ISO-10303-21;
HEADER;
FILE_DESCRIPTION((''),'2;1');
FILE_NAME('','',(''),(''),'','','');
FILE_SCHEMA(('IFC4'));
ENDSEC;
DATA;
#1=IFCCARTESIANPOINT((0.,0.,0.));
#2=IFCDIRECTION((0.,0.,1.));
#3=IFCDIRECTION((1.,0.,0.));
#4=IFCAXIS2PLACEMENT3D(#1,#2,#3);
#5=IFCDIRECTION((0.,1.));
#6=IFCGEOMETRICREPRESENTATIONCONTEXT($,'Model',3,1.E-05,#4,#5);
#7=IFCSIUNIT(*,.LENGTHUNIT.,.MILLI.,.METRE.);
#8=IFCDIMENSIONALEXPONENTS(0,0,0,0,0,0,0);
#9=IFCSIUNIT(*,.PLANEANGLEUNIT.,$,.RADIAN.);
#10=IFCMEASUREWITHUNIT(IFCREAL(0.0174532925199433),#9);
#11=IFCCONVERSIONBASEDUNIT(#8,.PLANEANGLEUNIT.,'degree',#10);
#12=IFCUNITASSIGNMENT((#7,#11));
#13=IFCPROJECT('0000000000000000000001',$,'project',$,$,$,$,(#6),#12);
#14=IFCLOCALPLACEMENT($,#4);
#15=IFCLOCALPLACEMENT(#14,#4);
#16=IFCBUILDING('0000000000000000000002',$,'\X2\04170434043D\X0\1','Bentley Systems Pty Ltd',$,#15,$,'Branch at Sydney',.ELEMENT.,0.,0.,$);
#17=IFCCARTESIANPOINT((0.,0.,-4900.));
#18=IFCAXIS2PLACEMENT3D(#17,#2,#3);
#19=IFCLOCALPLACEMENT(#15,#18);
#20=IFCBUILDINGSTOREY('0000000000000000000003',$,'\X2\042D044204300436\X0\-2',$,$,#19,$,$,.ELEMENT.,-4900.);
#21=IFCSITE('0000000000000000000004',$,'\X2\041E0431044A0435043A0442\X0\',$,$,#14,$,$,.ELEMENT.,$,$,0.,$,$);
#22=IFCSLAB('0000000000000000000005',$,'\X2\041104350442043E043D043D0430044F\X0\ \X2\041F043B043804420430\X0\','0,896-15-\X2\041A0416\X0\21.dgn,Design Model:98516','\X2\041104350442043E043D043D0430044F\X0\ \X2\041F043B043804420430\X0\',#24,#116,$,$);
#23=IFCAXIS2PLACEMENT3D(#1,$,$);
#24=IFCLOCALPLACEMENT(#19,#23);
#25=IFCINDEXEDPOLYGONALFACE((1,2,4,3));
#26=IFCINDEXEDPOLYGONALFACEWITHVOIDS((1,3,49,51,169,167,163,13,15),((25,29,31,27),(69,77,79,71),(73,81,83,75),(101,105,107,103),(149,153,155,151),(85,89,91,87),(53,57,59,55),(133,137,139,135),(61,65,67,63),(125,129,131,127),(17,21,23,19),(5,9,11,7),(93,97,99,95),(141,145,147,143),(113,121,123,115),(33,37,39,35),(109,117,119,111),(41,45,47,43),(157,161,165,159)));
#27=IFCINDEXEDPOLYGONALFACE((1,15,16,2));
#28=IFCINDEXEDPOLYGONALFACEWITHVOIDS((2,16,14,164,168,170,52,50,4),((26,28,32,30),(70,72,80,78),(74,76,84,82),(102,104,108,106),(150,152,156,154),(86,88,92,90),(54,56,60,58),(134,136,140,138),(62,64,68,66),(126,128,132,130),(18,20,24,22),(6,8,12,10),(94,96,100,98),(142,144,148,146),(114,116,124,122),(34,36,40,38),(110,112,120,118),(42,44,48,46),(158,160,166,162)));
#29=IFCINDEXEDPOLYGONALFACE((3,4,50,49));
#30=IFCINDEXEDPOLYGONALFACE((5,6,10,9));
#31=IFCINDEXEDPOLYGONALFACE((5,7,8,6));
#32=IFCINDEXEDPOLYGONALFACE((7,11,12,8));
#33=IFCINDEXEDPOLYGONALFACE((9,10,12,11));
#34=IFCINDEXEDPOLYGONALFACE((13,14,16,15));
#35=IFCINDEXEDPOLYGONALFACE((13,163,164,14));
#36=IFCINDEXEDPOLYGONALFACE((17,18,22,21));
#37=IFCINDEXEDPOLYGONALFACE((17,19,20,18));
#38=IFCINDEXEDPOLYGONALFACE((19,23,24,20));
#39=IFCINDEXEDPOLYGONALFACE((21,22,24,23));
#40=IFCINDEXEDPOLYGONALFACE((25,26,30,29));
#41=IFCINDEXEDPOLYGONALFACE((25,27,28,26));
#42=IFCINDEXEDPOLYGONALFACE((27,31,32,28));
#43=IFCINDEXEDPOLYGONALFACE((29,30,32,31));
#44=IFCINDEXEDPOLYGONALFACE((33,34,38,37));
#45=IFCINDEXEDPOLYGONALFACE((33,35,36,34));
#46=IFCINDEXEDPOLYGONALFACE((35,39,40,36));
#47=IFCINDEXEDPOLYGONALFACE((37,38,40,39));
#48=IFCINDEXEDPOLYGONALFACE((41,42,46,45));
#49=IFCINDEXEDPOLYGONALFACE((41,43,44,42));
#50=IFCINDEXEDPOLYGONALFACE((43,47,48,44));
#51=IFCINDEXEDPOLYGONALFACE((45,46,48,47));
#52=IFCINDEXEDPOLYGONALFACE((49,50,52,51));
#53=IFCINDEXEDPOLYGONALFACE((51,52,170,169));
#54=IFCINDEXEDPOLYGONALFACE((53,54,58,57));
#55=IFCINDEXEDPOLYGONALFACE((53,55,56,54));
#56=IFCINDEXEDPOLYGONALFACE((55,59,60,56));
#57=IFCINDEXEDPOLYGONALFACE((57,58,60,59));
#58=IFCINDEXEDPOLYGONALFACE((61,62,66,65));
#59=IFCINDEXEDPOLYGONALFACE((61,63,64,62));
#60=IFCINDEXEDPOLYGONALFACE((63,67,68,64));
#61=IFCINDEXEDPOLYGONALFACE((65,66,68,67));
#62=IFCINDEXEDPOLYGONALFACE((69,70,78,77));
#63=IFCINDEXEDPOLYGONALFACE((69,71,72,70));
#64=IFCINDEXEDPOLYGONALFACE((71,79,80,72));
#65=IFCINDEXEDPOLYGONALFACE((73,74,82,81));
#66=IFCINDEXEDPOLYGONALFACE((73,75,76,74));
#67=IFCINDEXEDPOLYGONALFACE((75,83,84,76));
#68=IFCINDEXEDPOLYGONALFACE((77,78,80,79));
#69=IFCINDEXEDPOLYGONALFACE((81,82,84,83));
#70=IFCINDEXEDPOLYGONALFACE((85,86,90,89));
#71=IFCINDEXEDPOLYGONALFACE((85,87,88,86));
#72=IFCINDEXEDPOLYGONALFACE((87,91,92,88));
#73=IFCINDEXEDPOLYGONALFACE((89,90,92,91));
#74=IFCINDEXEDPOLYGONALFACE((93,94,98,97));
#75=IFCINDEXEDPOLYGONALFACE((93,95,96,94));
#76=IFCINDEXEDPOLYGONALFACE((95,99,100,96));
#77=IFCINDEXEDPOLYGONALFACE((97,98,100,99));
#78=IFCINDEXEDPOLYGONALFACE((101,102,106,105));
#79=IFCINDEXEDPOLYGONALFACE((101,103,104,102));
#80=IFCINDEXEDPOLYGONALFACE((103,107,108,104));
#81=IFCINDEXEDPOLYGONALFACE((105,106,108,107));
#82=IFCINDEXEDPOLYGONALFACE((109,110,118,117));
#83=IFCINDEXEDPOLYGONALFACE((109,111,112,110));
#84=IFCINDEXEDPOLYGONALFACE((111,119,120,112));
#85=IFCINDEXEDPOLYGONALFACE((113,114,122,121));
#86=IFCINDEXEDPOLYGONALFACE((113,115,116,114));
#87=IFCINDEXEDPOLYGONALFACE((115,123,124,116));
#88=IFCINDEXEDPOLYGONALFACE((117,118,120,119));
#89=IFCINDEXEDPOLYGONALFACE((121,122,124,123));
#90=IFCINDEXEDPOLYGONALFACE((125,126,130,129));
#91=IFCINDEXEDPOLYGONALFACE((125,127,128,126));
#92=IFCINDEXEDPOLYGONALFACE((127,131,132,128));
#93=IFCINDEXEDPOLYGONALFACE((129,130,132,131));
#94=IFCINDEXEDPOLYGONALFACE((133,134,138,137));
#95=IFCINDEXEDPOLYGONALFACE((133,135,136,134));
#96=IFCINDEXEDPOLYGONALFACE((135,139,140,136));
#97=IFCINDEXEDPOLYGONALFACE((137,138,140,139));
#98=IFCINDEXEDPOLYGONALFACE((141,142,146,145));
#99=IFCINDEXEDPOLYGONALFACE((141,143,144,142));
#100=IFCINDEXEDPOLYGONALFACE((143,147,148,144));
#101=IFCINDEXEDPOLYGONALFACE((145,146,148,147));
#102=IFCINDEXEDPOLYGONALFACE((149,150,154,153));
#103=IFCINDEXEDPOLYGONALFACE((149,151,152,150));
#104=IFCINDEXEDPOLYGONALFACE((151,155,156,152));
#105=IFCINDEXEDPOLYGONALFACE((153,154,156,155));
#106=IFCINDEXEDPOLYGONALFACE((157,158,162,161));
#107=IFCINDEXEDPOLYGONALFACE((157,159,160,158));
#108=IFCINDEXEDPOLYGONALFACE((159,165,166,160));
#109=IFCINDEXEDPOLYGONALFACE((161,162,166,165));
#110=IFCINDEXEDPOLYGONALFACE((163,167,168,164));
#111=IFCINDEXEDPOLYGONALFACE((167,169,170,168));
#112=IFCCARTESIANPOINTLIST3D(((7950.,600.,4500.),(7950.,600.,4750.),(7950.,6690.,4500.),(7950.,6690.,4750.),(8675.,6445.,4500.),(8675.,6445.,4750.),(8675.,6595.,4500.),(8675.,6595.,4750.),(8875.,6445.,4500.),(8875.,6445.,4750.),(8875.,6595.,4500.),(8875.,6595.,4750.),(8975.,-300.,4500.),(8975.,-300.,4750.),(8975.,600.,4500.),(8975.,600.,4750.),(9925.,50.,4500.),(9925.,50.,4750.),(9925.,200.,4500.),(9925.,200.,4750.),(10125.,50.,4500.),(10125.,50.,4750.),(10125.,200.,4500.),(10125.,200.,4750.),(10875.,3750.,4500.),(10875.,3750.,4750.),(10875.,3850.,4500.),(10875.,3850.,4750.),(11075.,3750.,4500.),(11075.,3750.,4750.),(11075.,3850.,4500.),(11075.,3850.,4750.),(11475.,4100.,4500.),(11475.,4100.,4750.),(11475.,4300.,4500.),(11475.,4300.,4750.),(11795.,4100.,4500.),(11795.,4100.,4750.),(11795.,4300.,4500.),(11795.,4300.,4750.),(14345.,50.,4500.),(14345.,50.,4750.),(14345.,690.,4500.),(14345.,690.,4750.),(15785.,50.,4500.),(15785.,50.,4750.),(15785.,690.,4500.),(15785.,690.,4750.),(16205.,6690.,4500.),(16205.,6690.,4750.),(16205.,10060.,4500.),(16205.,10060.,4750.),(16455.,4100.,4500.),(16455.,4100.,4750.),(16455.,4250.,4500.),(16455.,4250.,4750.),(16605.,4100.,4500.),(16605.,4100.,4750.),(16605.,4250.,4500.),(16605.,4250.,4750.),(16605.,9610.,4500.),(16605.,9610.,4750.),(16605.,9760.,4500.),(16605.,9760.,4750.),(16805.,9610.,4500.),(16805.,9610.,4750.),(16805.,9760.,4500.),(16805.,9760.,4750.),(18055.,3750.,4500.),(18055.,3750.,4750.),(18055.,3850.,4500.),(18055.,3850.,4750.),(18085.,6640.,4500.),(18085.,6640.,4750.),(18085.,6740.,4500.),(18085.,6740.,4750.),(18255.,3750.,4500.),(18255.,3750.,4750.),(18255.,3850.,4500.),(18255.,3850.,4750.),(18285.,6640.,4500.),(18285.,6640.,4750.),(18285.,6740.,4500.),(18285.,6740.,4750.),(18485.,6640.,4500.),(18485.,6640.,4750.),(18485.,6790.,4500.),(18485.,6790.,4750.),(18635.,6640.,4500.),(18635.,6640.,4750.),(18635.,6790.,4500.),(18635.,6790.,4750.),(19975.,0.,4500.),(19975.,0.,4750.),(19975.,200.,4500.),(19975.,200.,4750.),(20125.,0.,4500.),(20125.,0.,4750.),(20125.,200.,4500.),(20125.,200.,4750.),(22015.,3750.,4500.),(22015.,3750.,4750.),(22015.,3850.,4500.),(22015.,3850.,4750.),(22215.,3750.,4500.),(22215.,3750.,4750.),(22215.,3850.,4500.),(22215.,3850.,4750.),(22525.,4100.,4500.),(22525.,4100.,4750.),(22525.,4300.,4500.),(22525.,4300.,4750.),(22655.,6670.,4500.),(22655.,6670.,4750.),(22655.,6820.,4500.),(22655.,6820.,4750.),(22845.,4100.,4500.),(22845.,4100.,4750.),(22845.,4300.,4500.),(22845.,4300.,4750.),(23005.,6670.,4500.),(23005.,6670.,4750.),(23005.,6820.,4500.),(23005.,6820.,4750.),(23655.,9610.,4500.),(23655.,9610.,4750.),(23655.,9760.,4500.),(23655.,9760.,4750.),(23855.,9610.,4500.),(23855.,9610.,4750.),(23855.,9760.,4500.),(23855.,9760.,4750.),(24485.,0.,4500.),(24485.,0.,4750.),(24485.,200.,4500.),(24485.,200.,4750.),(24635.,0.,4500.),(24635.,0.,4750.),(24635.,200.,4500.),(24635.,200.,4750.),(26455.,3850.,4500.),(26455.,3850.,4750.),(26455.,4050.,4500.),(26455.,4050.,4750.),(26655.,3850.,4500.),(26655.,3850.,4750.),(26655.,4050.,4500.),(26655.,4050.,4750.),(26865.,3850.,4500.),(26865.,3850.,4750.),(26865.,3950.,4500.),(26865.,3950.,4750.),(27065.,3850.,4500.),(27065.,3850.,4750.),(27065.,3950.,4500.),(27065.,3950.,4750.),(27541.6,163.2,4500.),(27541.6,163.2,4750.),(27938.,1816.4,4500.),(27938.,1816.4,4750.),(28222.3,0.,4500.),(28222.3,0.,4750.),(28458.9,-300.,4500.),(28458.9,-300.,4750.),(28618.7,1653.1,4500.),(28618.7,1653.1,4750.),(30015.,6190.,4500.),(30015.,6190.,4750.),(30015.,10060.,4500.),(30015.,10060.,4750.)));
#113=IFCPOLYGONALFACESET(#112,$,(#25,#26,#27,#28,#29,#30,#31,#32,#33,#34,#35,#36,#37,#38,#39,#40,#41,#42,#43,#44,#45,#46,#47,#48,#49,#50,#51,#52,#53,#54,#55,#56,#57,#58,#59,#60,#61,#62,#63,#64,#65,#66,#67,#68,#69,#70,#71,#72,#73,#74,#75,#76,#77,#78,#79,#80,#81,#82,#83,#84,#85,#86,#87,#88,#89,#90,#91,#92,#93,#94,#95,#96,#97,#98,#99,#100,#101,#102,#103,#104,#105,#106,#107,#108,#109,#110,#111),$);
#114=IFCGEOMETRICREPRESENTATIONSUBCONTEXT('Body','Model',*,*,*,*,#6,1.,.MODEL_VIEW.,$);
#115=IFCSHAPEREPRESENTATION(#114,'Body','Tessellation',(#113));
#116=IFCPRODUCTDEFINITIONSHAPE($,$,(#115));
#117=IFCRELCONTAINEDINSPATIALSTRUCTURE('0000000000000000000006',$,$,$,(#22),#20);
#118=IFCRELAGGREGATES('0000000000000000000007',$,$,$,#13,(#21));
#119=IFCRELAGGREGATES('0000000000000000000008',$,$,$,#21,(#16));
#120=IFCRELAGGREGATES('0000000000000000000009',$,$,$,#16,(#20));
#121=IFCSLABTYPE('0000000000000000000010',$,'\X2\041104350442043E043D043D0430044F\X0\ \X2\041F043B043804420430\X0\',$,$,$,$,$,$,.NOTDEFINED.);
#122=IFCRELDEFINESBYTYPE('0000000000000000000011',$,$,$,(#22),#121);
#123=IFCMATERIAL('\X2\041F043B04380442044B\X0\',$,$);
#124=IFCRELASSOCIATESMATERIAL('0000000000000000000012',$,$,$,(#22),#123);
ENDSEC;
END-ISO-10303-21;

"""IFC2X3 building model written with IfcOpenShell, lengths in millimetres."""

from ifc_helpers import new_model, entity, si_unit, converted_unit, direction, frame, frame_2d, origin_with_axes, place, context, subcontext, project, spatial, polyline, rectangle, outline, extrude, material, type_object, element, save


model = new_model("IFC2X3")

# Units and contexts
model_context = context("Model", 3, precision=1e-05, world=origin_with_axes(), true_north=direction((0.0, 1.0)))
body_context = subcontext(model_context, "Body", "Model", "MODEL_VIEW", scale=1.0)
ifc_project = project(units=[si_unit("LENGTHUNIT", "METRE", prefix="MILLI"), converted_unit("PLANEANGLEUNIT", "degree", entity("IfcReal", 0.0174532925199433), si_unit("PLANEANGLEUNIT", "RADIAN"), dimensions=[0, 0, 0, 0, 0, 0, 0])], contexts=[model_context])

# Site, building, storey
site_placement = place(None, origin_with_axes())
site = spatial("IfcSite", under=ifc_project, at=site_placement, Name="Объект", CompositionType="ELEMENT", RefElevation=0.0)
building_placement = place(site_placement, origin_with_axes())
building = spatial("IfcBuilding", under=site, at=building_placement, Name="Здн1", Description="Bentley Systems Pty Ltd", LongName="Branch at Sydney", CompositionType="ELEMENT", ElevationOfRefHeight=0.0, ElevationOfTerrain=0.0)
storey_placement = place(building_placement, frame((0.0, 0.0, -4900.0), z_axis=(0.0, 0.0, 1.0), x_axis=(1.0, 0.0, 0.0)))
storey = spatial("IfcBuildingStorey", under=building, at=storey_placement, Name="Этаж-2", CompositionType="ELEMENT", Elevation=-4900.0)

# Shared definitions
ifc_material_1 = material(Name="Плиты")
slab_type = type_object("IfcSlabType", Name="Бетонная Плита", PredefinedType="NOTDEFINED")

# Slab, openings
slab_1_placement = place(storey_placement, frame((7950.0, 6690.0, 4750.0), z_axis=(0.0, 0.0, -1.0), x_axis=(1.0, 0.0, 0.0)))
slab_1 = element("IfcSlab", 1, at=slab_1_placement, inside=storey, type_object=slab_type, material=ifc_material_1, Name="Бетонная Плита", Description="0,896-15-КЖ21.dgn,Design Model:98516", ObjectType="Бетонная Плита", context=body_context, shape_type="SweptSolid", body=[
    extrude(outline(polyline([(0.0, 0.0), (8255.0, 0.0), (8255.0, -3370.0), (22065.0, -3370.0), (22065.0, 500.0), (20508.9, 6990.0), (1025.0, 6990.0), (1025.0, 6090.0), (0.0, 6090.0), (0.0, 0.0)])), origin_with_axes(), (0.0, 0.0, 1.0), 250.0),
])
opening_1_placement = place(slab_1_placement, frame((6395.0, 6000.0, 0.0), z_axis=(0.0, 0.0, 1.0), x_axis=(1.0, 0.0, 0.0)))
element("IfcOpeningElement", 2, at=opening_1_placement, cuts=slab_1, ObjectType="Opening", context=body_context, shape_type="SweptSolid", body=[
    extrude(rectangle(XDim=1440.0, YDim=640.0, at=frame_2d((-720.0, 320.0), x_axis=(1.0, 0.0))), frame((0.0, 0.0, 375.0), z_axis=(0.0, 0.0, -1.0), x_axis=(-1.0, 0.0, 0.0)), (0.0, 0.0, 1.0), 750.0),
])
opening_2_placement = place(slab_1_placement, frame((1975.0, 6490.0, 0.0), z_axis=(0.0, 0.0, 1.0), x_axis=(1.0, 0.0, 0.0)))
element("IfcOpeningElement", 3, at=opening_2_placement, cuts=slab_1, ObjectType="Opening", context=body_context, shape_type="SweptSolid", body=[
    extrude(rectangle(XDim=200.0, YDim=150.0, at=frame_2d((-100.0, 75.0), x_axis=(1.0, 0.0))), frame((0.0, 0.0, 375.0), z_axis=(0.0, 0.0, -1.0), x_axis=(-1.0, 0.0, 0.0)), (0.0, 0.0, 1.0), 750.0),
])
opening_3_placement = place(slab_1_placement, frame((725.0, 95.0, 0.0), z_axis=(0.0, 0.0, 1.0), x_axis=(1.0, 0.0, 0.0)))
element("IfcOpeningElement", 4, at=opening_3_placement, cuts=slab_1, ObjectType="Opening", context=body_context, shape_type="SweptSolid", body=[
    extrude(rectangle(XDim=200.0, YDim=150.0, at=frame_2d((-100.0, 75.0), x_axis=(1.0, 0.0))), frame((0.0, 0.0, 375.0), z_axis=(0.0, 0.0, -1.0), x_axis=(-1.0, 0.0, 0.0)), (0.0, 0.0, 1.0), 750.0),
])
opening_4_placement = place(slab_1_placement, frame((2925.0, 2840.0, 0.0), z_axis=(0.0, 0.0, 1.0), x_axis=(1.0, 0.0, 0.0)))
element("IfcOpeningElement", 5, at=opening_4_placement, cuts=slab_1, ObjectType="Opening", context=body_context, shape_type="SweptSolid", body=[
    extrude(rectangle(XDim=200.0, YDim=100.0, at=frame_2d((-100.0, 50.0), x_axis=(1.0, 0.0))), frame((0.0, 0.0, 375.0), z_axis=(0.0, 0.0, -1.0), x_axis=(-1.0, 0.0, 0.0)), (0.0, 0.0, 1.0), 750.0),
])
opening_5_placement = place(slab_1_placement, frame((3525.0, 2390.0, 0.0), z_axis=(0.0, 0.0, 1.0), x_axis=(1.0, 0.0, 0.0)))
element("IfcOpeningElement", 6, at=opening_5_placement, cuts=slab_1, ObjectType="Opening", context=body_context, shape_type="SweptSolid", body=[
    extrude(rectangle(XDim=320.0, YDim=200.0, at=frame_2d((-160.0, 100.0), x_axis=(1.0, 0.0))), frame((0.0, 0.0, 375.0), z_axis=(0.0, 0.0, -1.0), x_axis=(-1.0, 0.0, 0.0)), (0.0, 0.0, 1.0), 750.0),
])
opening_6_placement = place(slab_1_placement, frame((12025.0, 6490.0, 0.0), z_axis=(0.0, 0.0, 1.0), x_axis=(1.0, 0.0, 0.0)))
element("IfcOpeningElement", 7, at=opening_6_placement, cuts=slab_1, ObjectType="Opening", context=body_context, shape_type="SweptSolid", body=[
    extrude(rectangle(XDim=150.0, YDim=200.0, at=frame_2d((-75.0, 100.0), x_axis=(1.0, 0.0))), frame((0.0, 0.0, 375.0), z_axis=(0.0, 0.0, -1.0), x_axis=(-1.0, 0.0, 0.0)), (0.0, 0.0, 1.0), 750.0),
])
opening_7_placement = place(slab_1_placement, frame((16535.0, 6490.0, 0.0), z_axis=(0.0, 0.0, 1.0), x_axis=(1.0, 0.0, 0.0)))
element("IfcOpeningElement", 8, at=opening_7_placement, cuts=slab_1, ObjectType="Opening", context=body_context, shape_type="SweptSolid", body=[
    extrude(rectangle(XDim=150.0, YDim=200.0, at=frame_2d((-75.0, 100.0), x_axis=(1.0, 0.0))), frame((0.0, 0.0, 375.0), z_axis=(0.0, 0.0, -1.0), x_axis=(-1.0, 0.0, 0.0)), (0.0, 0.0, 1.0), 750.0),
])
opening_8_placement = place(slab_1_placement, frame((19591.6, 4873.6, 0.0), z_axis=(0.0, 0.0, 1.0), x_axis=(1.0, 0.0, 0.0)))
element("IfcOpeningElement", 9, at=opening_8_placement, cuts=slab_1, ObjectType="Opening", context=body_context, shape_type="SweptSolid", body=[
    extrude(rectangle(XDim=1700.0, YDim=700.0, at=frame_2d((-538.5, 908.2), x_axis=(0.233165, 0.972437))), frame((0.0, 0.0, 375.0), z_axis=(0.0, 0.0, -1.0), x_axis=(-1.0, 0.0, 0.0)), (0.0, 0.0, 1.0), 750.0),
])
opening_9_placement = place(slab_1_placement, frame((8655.0, -3070.0, 0.0), z_axis=(0.0, 0.0, 1.0), x_axis=(1.0, 0.0, 0.0)))
element("IfcOpeningElement", 10, at=opening_9_placement, cuts=slab_1, ObjectType="Opening", context=body_context, shape_type="SweptSolid", body=[
    extrude(rectangle(XDim=200.0, YDim=150.0, at=frame_2d((-100.0, 75.0), x_axis=(1.0, 0.0))), frame((0.0, 0.0, 375.0), z_axis=(0.0, 0.0, -1.0), x_axis=(-1.0, 0.0, 0.0)), (0.0, 0.0, 1.0), 750.0),
])
opening_10_placement = place(slab_1_placement, frame((15705.0, -3070.0, 0.0), z_axis=(0.0, 0.0, 1.0), x_axis=(1.0, 0.0, 0.0)))
element("IfcOpeningElement", 11, at=opening_10_placement, cuts=slab_1, ObjectType="Opening", context=body_context, shape_type="SweptSolid", body=[
    extrude(rectangle(XDim=200.0, YDim=150.0, at=frame_2d((-100.0, 75.0), x_axis=(1.0, 0.0))), frame((0.0, 0.0, 375.0), z_axis=(0.0, 0.0, -1.0), x_axis=(-1.0, 0.0, 0.0)), (0.0, 0.0, 1.0), 750.0),
])
opening_11_placement = place(slab_1_placement, frame((10135.0, -50.0, 0.0), z_axis=(0.0, 0.0, 1.0), x_axis=(1.0, 0.0, 0.0)))
element("IfcOpeningElement", 12, at=opening_11_placement, cuts=slab_1, ObjectType="Opening", context=body_context, shape_type="SweptSolid", body=[
    extrude(rectangle(XDim=200.0, YDim=100.0, at=frame_2d((-100.0, 50.0), x_axis=(1.0, 0.0))), frame((0.0, 0.0, 375.0), z_axis=(0.0, 0.0, -1.0), x_axis=(-1.0, 0.0, 0.0)), (0.0, 0.0, 1.0), 750.0),
])
opening_12_placement = place(slab_1_placement, frame((10535.0, -100.0, 0.0), z_axis=(0.0, 0.0, 1.0), x_axis=(1.0, 0.0, 0.0)))
element("IfcOpeningElement", 13, at=opening_12_placement, cuts=slab_1, ObjectType="Opening", context=body_context, shape_type="SweptSolid", body=[
    extrude(rectangle(XDim=150.0, YDim=150.0, at=frame_2d((-75.0, 75.0), x_axis=(1.0, 0.0))), frame((0.0, 0.0, 375.0), z_axis=(0.0, 0.0, -1.0), x_axis=(-1.0, 0.0, 0.0)), (0.0, 0.0, 1.0), 750.0),
])
opening_13_placement = place(slab_1_placement, frame((14705.0, -130.0, 0.0), z_axis=(0.0, 0.0, 1.0), x_axis=(1.0, 0.0, 0.0)))
element("IfcOpeningElement", 14, at=opening_13_placement, cuts=slab_1, ObjectType="Opening", context=body_context, shape_type="SweptSolid", body=[
    extrude(rectangle(XDim=350.0, YDim=150.0, at=frame_2d((-175.0, 75.0), x_axis=(1.0, 0.0))), frame((0.0, 0.0, 375.0), z_axis=(0.0, 0.0, -1.0), x_axis=(-1.0, 0.0, 0.0)), (0.0, 0.0, 1.0), 750.0),
])
opening_14_placement = place(slab_1_placement, frame((8505.0, 2440.0, 0.0), z_axis=(0.0, 0.0, 1.0), x_axis=(1.0, 0.0, 0.0)))
element("IfcOpeningElement", 15, at=opening_14_placement, cuts=slab_1, ObjectType="Opening", context=body_context, shape_type="SweptSolid", body=[
    extrude(rectangle(XDim=150.0, YDim=150.0, at=frame_2d((-75.0, 75.0), x_axis=(1.0, 0.0))), frame((0.0, 0.0, 375.0), z_axis=(0.0, 0.0, -1.0), x_axis=(-1.0, 0.0, 0.0)), (0.0, 0.0, 1.0), 750.0),
])
opening_15_placement = place(slab_1_placement, frame((10105.0, 2840.0, 0.0), z_axis=(0.0, 0.0, 1.0), x_axis=(1.0, 0.0, 0.0)))
element("IfcOpeningElement", 16, at=opening_15_placement, cuts=slab_1, ObjectType="Opening", context=body_context, shape_type="SweptSolid", body=[
    extrude(rectangle(XDim=200.0, YDim=100.0, at=frame_2d((-100.0, 50.0), x_axis=(1.0, 0.0))), frame((0.0, 0.0, 375.0), z_axis=(0.0, 0.0, -1.0), x_axis=(-1.0, 0.0, 0.0)), (0.0, 0.0, 1.0), 750.0),
])
opening_16_placement = place(slab_1_placement, frame((14065.0, 2840.0, 0.0), z_axis=(0.0, 0.0, 1.0), x_axis=(1.0, 0.0, 0.0)))
element("IfcOpeningElement", 17, at=opening_16_placement, cuts=slab_1, ObjectType="Opening", context=body_context, shape_type="SweptSolid", body=[
    extrude(rectangle(XDim=200.0, YDim=100.0, at=frame_2d((-100.0, 50.0), x_axis=(1.0, 0.0))), frame((0.0, 0.0, 375.0), z_axis=(0.0, 0.0, -1.0), x_axis=(-1.0, 0.0, 0.0)), (0.0, 0.0, 1.0), 750.0),
])
opening_17_placement = place(slab_1_placement, frame((14575.0, 2390.0, 0.0), z_axis=(0.0, 0.0, 1.0), x_axis=(1.0, 0.0, 0.0)))
element("IfcOpeningElement", 18, at=opening_17_placement, cuts=slab_1, ObjectType="Opening", context=body_context, shape_type="SweptSolid", body=[
    extrude(rectangle(XDim=320.0, YDim=200.0, at=frame_2d((-160.0, 100.0), x_axis=(1.0, 0.0))), frame((0.0, 0.0, 375.0), z_axis=(0.0, 0.0, -1.0), x_axis=(-1.0, 0.0, 0.0)), (0.0, 0.0, 1.0), 750.0),
])
opening_18_placement = place(slab_1_placement, frame((18505.0, 2640.0, 0.0), z_axis=(0.0, 0.0, 1.0), x_axis=(1.0, 0.0, 0.0)))
element("IfcOpeningElement", 19, at=opening_18_placement, cuts=slab_1, ObjectType="Opening", context=body_context, shape_type="SweptSolid", body=[
    extrude(rectangle(XDim=200.0, YDim=200.0, at=frame_2d((-100.0, 100.0), x_axis=(1.0, 0.0))), frame((0.0, 0.0, 375.0), z_axis=(0.0, 0.0, -1.0), x_axis=(-1.0, 0.0, 0.0)), (0.0, 0.0, 1.0), 750.0),
])
opening_19_placement = place(slab_1_placement, frame((18915.0, 2740.0, 0.0), z_axis=(0.0, 0.0, 1.0), x_axis=(1.0, 0.0, 0.0)))
element("IfcOpeningElement", 20, at=opening_19_placement, cuts=slab_1, ObjectType="Opening", context=body_context, shape_type="SweptSolid", body=[
    extrude(rectangle(XDim=200.0, YDim=100.0, at=frame_2d((-100.0, 50.0), x_axis=(1.0, 0.0))), frame((0.0, 0.0, 375.0), z_axis=(0.0, 0.0, -1.0), x_axis=(-1.0, 0.0, 0.0)), (0.0, 0.0, 1.0), 750.0),
])

save(model, "model.ifc")
